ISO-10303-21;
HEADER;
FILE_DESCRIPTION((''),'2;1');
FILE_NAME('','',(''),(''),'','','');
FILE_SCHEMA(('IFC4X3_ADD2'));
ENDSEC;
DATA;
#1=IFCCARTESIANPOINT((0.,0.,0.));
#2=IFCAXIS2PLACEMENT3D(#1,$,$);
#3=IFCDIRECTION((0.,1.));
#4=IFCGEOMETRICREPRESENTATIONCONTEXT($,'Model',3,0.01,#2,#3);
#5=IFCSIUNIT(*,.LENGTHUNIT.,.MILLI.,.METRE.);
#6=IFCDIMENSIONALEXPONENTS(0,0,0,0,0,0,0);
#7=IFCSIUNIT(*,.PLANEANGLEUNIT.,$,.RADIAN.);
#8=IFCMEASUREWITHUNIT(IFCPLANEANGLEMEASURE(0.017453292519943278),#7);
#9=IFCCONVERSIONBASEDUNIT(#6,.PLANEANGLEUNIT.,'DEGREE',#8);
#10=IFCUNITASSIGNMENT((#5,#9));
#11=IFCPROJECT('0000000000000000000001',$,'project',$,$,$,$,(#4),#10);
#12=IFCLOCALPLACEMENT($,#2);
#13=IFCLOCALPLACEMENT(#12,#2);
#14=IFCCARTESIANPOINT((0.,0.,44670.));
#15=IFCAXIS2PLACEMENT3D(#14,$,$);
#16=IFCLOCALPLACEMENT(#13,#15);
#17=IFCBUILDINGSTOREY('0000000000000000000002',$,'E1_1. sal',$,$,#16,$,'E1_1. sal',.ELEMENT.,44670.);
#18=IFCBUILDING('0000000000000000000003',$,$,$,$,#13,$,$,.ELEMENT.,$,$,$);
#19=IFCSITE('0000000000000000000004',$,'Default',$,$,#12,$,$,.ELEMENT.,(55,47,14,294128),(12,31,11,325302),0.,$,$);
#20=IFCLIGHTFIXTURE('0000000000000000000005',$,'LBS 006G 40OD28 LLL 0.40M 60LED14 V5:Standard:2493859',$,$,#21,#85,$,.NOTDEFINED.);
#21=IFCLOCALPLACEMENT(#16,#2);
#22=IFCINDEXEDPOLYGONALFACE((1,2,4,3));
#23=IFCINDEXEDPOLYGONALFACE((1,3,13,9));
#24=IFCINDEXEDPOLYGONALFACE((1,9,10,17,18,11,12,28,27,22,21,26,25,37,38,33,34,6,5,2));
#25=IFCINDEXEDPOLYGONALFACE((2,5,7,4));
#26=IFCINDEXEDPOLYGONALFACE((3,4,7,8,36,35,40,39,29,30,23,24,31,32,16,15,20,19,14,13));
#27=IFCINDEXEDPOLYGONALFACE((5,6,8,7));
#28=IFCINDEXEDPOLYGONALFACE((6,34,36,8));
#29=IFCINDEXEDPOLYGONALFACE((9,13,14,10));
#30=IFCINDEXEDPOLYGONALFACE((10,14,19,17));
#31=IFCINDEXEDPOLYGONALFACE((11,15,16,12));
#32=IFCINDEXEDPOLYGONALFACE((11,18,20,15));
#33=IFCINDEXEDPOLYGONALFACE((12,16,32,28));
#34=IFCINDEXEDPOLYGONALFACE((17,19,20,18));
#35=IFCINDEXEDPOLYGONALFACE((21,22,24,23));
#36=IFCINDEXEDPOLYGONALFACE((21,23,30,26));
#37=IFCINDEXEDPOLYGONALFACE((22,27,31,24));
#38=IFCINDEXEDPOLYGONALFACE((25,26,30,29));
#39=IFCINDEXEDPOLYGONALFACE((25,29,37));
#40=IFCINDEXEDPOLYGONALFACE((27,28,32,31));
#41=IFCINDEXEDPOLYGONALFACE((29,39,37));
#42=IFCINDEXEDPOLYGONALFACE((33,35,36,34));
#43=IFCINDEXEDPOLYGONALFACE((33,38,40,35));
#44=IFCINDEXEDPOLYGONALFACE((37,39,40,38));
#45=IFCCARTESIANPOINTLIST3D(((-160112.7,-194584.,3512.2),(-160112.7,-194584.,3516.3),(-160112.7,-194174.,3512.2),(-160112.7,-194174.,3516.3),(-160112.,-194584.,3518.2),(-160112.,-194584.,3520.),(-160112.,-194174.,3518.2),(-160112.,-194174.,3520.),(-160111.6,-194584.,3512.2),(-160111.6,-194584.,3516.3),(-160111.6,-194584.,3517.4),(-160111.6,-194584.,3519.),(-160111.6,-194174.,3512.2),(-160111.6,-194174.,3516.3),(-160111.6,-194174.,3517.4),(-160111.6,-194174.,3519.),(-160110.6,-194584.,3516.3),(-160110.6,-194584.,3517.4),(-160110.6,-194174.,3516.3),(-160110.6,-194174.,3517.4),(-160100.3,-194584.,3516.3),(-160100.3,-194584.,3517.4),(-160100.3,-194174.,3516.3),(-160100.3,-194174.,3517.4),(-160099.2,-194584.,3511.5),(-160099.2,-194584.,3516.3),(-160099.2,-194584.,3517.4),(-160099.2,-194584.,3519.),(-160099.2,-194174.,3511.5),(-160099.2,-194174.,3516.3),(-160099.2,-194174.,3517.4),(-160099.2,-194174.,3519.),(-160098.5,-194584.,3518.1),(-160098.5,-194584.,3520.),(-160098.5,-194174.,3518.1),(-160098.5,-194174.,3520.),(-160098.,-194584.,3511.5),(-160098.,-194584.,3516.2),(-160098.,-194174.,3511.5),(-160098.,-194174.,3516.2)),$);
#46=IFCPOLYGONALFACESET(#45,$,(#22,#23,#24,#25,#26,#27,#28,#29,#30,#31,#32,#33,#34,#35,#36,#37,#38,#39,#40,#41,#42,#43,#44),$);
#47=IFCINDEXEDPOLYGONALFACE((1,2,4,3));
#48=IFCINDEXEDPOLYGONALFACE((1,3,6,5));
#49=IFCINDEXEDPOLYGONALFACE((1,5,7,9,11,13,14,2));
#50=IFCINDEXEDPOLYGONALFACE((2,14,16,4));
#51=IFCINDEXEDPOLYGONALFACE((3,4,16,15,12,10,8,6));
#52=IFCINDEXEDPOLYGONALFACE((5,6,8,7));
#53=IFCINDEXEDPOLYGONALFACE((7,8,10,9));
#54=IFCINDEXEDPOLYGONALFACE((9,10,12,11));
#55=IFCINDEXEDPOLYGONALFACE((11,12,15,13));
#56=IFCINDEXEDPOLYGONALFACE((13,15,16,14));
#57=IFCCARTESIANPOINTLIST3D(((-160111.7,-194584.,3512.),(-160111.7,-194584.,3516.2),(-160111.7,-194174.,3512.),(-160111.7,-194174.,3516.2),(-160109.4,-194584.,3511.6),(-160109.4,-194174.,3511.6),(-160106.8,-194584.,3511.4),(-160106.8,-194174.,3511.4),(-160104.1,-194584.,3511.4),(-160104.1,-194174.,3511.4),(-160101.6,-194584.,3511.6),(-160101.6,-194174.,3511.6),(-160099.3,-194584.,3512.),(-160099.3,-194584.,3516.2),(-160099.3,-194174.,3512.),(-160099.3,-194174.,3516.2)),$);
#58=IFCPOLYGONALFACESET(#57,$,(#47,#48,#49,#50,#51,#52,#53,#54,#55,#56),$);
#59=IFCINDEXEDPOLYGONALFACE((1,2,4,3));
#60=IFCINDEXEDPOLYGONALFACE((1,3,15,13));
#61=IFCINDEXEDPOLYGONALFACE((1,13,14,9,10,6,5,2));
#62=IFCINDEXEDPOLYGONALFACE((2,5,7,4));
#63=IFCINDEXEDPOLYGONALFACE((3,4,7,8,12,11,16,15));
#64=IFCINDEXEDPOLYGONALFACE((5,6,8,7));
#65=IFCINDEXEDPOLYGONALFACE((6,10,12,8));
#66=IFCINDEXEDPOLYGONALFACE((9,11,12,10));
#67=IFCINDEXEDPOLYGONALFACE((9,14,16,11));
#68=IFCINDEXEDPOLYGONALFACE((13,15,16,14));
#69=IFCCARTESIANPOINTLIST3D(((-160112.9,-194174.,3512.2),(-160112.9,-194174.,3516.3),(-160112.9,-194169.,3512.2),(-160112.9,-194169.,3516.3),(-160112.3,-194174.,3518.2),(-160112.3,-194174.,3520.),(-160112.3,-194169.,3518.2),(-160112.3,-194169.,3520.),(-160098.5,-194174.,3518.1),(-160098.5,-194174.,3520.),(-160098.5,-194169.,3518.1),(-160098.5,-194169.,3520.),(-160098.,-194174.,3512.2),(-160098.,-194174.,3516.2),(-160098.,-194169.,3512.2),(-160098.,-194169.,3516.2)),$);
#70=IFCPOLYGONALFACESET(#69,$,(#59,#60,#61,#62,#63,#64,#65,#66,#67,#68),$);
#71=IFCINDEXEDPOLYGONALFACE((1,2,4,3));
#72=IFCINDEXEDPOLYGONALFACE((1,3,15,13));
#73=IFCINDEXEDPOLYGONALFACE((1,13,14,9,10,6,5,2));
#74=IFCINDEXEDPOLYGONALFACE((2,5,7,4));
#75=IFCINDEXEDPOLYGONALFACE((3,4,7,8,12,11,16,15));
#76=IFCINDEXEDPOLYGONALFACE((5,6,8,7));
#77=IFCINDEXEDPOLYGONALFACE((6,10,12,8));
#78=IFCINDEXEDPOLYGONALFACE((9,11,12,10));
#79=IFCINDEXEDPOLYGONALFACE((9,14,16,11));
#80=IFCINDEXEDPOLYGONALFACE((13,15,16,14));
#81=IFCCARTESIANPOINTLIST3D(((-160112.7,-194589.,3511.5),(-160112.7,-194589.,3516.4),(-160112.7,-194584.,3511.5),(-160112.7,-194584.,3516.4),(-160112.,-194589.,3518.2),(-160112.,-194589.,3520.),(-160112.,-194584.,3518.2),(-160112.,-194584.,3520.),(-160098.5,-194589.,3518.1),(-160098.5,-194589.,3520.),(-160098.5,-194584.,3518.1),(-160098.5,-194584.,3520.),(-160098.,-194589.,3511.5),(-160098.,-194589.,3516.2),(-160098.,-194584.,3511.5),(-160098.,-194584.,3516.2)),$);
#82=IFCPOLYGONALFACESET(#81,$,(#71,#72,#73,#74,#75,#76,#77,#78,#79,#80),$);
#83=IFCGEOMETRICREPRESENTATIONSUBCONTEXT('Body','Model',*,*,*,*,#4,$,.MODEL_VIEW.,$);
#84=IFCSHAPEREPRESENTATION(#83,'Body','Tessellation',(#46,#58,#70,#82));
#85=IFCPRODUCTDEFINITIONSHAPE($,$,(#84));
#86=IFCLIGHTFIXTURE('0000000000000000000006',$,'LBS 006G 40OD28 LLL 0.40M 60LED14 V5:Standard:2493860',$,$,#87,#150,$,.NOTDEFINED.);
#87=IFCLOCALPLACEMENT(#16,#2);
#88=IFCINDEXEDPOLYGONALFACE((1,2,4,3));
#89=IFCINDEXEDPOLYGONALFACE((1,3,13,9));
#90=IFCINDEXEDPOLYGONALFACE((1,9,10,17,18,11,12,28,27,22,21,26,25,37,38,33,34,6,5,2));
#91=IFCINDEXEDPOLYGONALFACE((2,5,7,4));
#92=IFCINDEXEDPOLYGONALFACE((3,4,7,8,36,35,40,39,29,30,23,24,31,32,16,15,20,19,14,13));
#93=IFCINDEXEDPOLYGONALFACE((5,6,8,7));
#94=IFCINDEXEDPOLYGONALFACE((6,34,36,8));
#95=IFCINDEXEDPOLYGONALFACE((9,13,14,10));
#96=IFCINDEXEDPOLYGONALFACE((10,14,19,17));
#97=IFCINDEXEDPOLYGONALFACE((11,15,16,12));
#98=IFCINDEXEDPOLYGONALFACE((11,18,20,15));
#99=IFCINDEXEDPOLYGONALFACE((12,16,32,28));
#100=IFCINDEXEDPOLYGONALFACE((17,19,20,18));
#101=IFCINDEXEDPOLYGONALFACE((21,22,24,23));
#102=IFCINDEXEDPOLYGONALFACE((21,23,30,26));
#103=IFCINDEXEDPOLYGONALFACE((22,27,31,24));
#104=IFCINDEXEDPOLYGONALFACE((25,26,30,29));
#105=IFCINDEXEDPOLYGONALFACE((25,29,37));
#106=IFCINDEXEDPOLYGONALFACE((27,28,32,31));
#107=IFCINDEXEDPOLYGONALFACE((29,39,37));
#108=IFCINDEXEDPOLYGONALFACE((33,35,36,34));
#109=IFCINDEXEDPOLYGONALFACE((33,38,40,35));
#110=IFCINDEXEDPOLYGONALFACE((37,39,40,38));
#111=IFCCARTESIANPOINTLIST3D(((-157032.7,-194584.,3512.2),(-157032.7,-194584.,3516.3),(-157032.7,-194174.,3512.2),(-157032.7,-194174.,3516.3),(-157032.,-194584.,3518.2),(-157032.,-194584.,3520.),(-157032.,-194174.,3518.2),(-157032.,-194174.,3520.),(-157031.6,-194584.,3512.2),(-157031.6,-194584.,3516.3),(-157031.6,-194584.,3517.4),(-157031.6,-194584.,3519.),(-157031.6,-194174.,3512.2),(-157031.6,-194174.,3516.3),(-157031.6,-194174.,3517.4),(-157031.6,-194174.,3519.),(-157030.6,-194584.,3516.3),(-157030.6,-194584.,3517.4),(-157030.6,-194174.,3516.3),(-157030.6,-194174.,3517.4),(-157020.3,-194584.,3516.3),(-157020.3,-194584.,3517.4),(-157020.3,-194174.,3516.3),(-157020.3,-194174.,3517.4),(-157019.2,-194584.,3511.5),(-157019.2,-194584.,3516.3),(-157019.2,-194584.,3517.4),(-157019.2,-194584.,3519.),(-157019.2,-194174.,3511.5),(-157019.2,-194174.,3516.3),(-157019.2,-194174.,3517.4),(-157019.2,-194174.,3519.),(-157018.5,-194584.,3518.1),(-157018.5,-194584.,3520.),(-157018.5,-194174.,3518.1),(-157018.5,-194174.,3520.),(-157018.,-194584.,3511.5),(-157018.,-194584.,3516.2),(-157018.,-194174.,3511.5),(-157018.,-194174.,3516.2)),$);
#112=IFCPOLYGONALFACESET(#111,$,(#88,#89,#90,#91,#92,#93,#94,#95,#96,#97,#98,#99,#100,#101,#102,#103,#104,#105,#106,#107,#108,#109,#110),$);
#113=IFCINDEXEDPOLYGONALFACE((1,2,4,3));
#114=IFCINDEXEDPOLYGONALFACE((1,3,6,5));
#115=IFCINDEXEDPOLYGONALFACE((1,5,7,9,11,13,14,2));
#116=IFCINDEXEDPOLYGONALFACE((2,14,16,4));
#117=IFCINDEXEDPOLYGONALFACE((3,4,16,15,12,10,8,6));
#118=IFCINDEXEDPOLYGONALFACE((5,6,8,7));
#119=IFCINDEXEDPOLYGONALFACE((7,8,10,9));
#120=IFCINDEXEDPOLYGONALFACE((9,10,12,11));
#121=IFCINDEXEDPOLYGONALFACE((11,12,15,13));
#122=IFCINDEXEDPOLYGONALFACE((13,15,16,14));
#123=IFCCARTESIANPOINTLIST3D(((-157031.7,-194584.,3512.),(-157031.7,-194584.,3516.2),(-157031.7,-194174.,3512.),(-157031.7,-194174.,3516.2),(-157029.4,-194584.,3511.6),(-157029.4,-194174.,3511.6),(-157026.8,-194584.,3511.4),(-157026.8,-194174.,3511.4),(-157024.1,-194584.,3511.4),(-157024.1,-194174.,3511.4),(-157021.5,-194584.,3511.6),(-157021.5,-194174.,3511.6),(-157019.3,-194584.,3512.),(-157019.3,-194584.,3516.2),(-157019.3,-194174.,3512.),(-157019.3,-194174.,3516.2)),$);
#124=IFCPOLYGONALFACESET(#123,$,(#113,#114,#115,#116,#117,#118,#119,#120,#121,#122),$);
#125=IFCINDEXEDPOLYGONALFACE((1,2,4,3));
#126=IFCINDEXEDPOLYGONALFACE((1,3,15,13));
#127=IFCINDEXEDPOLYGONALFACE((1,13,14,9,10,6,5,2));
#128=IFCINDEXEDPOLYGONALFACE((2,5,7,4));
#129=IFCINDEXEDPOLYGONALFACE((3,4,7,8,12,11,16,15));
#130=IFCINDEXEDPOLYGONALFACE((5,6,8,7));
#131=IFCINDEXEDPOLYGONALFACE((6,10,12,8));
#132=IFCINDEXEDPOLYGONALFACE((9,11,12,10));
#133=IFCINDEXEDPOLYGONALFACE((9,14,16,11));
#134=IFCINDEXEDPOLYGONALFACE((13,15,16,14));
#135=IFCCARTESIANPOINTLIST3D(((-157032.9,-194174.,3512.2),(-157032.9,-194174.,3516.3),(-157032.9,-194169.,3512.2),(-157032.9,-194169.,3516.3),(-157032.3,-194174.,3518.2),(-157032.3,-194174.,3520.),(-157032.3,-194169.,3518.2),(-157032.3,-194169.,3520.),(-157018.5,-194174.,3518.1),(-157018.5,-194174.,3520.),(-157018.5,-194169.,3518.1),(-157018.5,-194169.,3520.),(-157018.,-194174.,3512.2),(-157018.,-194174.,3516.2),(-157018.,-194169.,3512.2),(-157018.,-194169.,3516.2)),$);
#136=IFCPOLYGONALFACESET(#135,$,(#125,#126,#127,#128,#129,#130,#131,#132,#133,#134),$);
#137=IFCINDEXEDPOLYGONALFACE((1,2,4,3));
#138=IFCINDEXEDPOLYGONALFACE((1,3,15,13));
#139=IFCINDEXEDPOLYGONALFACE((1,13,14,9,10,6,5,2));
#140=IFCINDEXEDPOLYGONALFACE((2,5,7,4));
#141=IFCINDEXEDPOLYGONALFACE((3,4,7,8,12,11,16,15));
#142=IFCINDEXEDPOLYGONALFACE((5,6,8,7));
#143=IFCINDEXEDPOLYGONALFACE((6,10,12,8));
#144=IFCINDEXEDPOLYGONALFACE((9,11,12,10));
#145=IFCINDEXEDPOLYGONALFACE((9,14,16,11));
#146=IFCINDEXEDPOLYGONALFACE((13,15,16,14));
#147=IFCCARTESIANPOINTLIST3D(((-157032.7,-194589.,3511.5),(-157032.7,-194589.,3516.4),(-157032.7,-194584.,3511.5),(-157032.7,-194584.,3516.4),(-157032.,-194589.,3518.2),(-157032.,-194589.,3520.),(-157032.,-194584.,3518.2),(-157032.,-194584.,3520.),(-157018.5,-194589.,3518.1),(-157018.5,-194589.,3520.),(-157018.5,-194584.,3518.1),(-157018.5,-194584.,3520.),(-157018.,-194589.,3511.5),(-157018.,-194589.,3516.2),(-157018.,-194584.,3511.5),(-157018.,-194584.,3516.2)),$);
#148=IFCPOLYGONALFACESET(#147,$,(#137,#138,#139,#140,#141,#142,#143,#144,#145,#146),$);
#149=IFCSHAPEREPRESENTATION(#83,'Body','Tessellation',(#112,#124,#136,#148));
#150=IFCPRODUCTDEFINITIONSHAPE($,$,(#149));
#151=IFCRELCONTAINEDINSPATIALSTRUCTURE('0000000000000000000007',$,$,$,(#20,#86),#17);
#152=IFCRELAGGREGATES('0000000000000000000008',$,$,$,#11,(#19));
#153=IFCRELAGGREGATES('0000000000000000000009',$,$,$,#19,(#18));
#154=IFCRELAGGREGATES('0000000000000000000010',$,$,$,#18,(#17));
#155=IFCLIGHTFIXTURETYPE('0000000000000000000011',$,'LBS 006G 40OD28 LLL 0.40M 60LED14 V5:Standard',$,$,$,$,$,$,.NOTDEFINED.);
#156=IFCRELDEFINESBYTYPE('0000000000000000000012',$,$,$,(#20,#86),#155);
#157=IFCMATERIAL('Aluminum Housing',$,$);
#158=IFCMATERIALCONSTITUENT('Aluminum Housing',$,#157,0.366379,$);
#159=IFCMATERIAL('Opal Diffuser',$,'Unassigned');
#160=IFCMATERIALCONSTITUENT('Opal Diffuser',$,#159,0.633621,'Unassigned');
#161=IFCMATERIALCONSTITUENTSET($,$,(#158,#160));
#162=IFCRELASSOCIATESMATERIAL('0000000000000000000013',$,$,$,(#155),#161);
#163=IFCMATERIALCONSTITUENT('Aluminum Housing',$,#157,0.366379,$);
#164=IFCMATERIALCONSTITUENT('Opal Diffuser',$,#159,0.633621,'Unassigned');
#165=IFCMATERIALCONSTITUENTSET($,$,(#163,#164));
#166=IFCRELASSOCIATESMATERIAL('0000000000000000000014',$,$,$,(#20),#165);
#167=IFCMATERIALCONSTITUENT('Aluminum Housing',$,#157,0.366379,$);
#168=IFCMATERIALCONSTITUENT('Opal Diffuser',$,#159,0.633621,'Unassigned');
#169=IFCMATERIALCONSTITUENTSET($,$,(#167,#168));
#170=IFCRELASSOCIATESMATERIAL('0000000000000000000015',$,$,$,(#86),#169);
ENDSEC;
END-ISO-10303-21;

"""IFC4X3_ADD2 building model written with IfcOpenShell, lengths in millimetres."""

from ifc_helpers import new_model, entity, si_unit, converted_unit, direction, frame, origin, place, context, subcontext, project, spatial, polyline, outline, extrude, source, transform, mapped, material, constituent, constituent_set, type_object, type_shapes, element, save


model = new_model("IFC4X3_ADD2")

# Units and contexts
model_context = context("Model", 3, precision=0.01, world=origin(), true_north=direction((0.0, 1.0)))
body_context = subcontext(model_context, "Body", "Model", "MODEL_VIEW")
ifc_project = project(units=[si_unit("LENGTHUNIT", "METRE", prefix="MILLI"), converted_unit("PLANEANGLEUNIT", "DEGREE", entity("IfcPlaneAngleMeasure", 0.017453292519943278), si_unit("PLANEANGLEUNIT", "RADIAN"), dimensions=[0, 0, 0, 0, 0, 0, 0])], contexts=[model_context])

# Site, building, storey
site_placement = place(None, origin())
site = spatial("IfcSite", under=ifc_project, at=site_placement, Name="Default", CompositionType="ELEMENT", RefLatitude=(55, 47, 14, 294128), RefLongitude=(12, 31, 11, 325302), RefElevation=0.0)
building_placement = place(site_placement, origin())
building = spatial("IfcBuilding", under=site, at=building_placement, CompositionType="ELEMENT")
storey_placement = place(building_placement, frame((0.0, 0.0, 44670.0)))
storey = spatial("IfcBuildingStorey", under=building, at=storey_placement, Name="E1_1. sal", LongName="E1_1. sal", CompositionType="ELEMENT", Elevation=44670.0)

# Light fixtures
ifc_material_1 = material(Name="Aluminum Housing")
ifc_material_2 = material(Name="Opal Diffuser", Category="Unassigned")
ifc_constituent_1 = constituent(ifc_material_1, Name="Aluminum Housing", fraction=0.366379)
ifc_constituent_2 = constituent(ifc_material_2, Name="Opal Diffuser", Category="Unassigned", fraction=0.633621)
ifc_constituent_set_1 = constituent_set(constituents=[ifc_constituent_1, ifc_constituent_2])
light_fixture_type = type_object("IfcLightFixtureType", Name="LBS 006G 40OD28 LLL 0.40M 60LED14 V5:Standard", PredefinedType="NOTDEFINED", material=ifc_constituent_set_1)
shared_shape_1 = source(origin(), body_context, "Body", "SweptSolid", [
    extrude(outline(polyline([(-5.0, -6.1), (-5.0, -7.4), (-0.3, -7.4), (1.7, -6.8), (3.5, -6.8), (3.5, 6.7), (1.8, 6.7), (-0.1, 7.3), (-4.2, 7.3), (-4.2, 6.2), (-0.1, 6.2), (-0.1, 5.2), (0.9, 5.2), (0.9, 6.2), (2.5, 6.2), (2.5, -6.1), (0.9, -6.1), (0.9, -5.1), (-0.1, -5.1), (-0.1, -6.1), (-5.0, -6.1)])), frame((-205.0, 0.1, 3.5), z_axis=(-1.0, 0.0, 0.0), x_axis=(0.0, 0.0, -1.0)), (0.0, 0.0, -1.0), 410.0),
    extrude(outline(polyline([(-0.8, -6.2), (3.4, -6.2), (3.4, 6.2), (-0.8, 6.2), (-1.2, 3.9), (-1.4, 1.4), (-1.4, -1.3), (-1.2, -3.9), (-0.8, -6.2)])), frame((-205.0, 0.0, 7.2), z_axis=(1.0, 0.0, 0.0), x_axis=(0.0, 0.0, -1.0)), (0.0, 0.0, 1.0), 410.0),
    extrude(outline(polyline([(-4.4, -7.5), (-0.3, -7.5), (1.5, -6.8), (3.3, -6.8), (3.3, 6.9), (1.5, 6.9), (-0.5, 7.4), (-4.4, 7.4), (-4.4, -7.5)])), frame((205.0, 0.0, 3.3), z_axis=(1.0, 0.0, 0.0), x_axis=(0.0, 0.0, -1.0)), (0.0, 0.0, 1.0), 5.0),
    extrude(outline(polyline([(-5.0, -7.4), (-0.1, -7.4), (1.7, -6.7), (3.5, -6.7), (3.5, 6.8), (1.6, 6.8), (-0.3, 7.3), (-5.0, 7.3), (-5.0, -7.4)])), frame((-210.0, 0.2, 3.5), z_axis=(1.0, 0.0, 0.0), x_axis=(0.0, 0.0, -1.0)), (0.0, 0.0, 1.0), 5.0),
])
type_shapes(light_fixture_type, [shared_shape_1])
ifc_constituent_3 = constituent(ifc_material_1, Name="Aluminum Housing", fraction=0.366379)
ifc_constituent_4 = constituent(ifc_material_2, Name="Opal Diffuser", Category="Unassigned", fraction=0.633621)
ifc_constituent_set_2 = constituent_set(constituents=[ifc_constituent_3, ifc_constituent_4])
light_fixture_1_placement = place(storey_placement, frame((-160105.5, -194379.0, 3520.0), z_axis=(0.0, 0.0, -1.0), x_axis=(0.0, 1.0, 0.0)))
element("IfcLightFixture", 1, at=light_fixture_1_placement, inside=storey, type_object=light_fixture_type, material=ifc_constituent_set_2, Name="LBS 006G 40OD28 LLL 0.40M 60LED14 V5:Standard:2493859", PredefinedType="NOTDEFINED", context=body_context, shape_type="MappedRepresentation", body=[
    mapped(shared_shape_1, transform((0.0, 0.0, 0.0), scale=1.0)),
])
ifc_constituent_5 = constituent(ifc_material_1, Name="Aluminum Housing", fraction=0.366379)
ifc_constituent_6 = constituent(ifc_material_2, Name="Opal Diffuser", Category="Unassigned", fraction=0.633621)
ifc_constituent_set_3 = constituent_set(constituents=[ifc_constituent_5, ifc_constituent_6])
light_fixture_2_placement = place(storey_placement, frame((-157025.5, -194379.0, 3520.0), z_axis=(0.0, 0.0, -1.0), x_axis=(0.0, 1.0, 0.0)))
element("IfcLightFixture", 2, at=light_fixture_2_placement, inside=storey, type_object=light_fixture_type, material=ifc_constituent_set_3, Name="LBS 006G 40OD28 LLL 0.40M 60LED14 V5:Standard:2493860", PredefinedType="NOTDEFINED", context=body_context, shape_type="MappedRepresentation", body=[
    mapped(shared_shape_1, transform((0.0, 0.0, 0.0), scale=1.0)),
])

save(model, "model.ifc")
